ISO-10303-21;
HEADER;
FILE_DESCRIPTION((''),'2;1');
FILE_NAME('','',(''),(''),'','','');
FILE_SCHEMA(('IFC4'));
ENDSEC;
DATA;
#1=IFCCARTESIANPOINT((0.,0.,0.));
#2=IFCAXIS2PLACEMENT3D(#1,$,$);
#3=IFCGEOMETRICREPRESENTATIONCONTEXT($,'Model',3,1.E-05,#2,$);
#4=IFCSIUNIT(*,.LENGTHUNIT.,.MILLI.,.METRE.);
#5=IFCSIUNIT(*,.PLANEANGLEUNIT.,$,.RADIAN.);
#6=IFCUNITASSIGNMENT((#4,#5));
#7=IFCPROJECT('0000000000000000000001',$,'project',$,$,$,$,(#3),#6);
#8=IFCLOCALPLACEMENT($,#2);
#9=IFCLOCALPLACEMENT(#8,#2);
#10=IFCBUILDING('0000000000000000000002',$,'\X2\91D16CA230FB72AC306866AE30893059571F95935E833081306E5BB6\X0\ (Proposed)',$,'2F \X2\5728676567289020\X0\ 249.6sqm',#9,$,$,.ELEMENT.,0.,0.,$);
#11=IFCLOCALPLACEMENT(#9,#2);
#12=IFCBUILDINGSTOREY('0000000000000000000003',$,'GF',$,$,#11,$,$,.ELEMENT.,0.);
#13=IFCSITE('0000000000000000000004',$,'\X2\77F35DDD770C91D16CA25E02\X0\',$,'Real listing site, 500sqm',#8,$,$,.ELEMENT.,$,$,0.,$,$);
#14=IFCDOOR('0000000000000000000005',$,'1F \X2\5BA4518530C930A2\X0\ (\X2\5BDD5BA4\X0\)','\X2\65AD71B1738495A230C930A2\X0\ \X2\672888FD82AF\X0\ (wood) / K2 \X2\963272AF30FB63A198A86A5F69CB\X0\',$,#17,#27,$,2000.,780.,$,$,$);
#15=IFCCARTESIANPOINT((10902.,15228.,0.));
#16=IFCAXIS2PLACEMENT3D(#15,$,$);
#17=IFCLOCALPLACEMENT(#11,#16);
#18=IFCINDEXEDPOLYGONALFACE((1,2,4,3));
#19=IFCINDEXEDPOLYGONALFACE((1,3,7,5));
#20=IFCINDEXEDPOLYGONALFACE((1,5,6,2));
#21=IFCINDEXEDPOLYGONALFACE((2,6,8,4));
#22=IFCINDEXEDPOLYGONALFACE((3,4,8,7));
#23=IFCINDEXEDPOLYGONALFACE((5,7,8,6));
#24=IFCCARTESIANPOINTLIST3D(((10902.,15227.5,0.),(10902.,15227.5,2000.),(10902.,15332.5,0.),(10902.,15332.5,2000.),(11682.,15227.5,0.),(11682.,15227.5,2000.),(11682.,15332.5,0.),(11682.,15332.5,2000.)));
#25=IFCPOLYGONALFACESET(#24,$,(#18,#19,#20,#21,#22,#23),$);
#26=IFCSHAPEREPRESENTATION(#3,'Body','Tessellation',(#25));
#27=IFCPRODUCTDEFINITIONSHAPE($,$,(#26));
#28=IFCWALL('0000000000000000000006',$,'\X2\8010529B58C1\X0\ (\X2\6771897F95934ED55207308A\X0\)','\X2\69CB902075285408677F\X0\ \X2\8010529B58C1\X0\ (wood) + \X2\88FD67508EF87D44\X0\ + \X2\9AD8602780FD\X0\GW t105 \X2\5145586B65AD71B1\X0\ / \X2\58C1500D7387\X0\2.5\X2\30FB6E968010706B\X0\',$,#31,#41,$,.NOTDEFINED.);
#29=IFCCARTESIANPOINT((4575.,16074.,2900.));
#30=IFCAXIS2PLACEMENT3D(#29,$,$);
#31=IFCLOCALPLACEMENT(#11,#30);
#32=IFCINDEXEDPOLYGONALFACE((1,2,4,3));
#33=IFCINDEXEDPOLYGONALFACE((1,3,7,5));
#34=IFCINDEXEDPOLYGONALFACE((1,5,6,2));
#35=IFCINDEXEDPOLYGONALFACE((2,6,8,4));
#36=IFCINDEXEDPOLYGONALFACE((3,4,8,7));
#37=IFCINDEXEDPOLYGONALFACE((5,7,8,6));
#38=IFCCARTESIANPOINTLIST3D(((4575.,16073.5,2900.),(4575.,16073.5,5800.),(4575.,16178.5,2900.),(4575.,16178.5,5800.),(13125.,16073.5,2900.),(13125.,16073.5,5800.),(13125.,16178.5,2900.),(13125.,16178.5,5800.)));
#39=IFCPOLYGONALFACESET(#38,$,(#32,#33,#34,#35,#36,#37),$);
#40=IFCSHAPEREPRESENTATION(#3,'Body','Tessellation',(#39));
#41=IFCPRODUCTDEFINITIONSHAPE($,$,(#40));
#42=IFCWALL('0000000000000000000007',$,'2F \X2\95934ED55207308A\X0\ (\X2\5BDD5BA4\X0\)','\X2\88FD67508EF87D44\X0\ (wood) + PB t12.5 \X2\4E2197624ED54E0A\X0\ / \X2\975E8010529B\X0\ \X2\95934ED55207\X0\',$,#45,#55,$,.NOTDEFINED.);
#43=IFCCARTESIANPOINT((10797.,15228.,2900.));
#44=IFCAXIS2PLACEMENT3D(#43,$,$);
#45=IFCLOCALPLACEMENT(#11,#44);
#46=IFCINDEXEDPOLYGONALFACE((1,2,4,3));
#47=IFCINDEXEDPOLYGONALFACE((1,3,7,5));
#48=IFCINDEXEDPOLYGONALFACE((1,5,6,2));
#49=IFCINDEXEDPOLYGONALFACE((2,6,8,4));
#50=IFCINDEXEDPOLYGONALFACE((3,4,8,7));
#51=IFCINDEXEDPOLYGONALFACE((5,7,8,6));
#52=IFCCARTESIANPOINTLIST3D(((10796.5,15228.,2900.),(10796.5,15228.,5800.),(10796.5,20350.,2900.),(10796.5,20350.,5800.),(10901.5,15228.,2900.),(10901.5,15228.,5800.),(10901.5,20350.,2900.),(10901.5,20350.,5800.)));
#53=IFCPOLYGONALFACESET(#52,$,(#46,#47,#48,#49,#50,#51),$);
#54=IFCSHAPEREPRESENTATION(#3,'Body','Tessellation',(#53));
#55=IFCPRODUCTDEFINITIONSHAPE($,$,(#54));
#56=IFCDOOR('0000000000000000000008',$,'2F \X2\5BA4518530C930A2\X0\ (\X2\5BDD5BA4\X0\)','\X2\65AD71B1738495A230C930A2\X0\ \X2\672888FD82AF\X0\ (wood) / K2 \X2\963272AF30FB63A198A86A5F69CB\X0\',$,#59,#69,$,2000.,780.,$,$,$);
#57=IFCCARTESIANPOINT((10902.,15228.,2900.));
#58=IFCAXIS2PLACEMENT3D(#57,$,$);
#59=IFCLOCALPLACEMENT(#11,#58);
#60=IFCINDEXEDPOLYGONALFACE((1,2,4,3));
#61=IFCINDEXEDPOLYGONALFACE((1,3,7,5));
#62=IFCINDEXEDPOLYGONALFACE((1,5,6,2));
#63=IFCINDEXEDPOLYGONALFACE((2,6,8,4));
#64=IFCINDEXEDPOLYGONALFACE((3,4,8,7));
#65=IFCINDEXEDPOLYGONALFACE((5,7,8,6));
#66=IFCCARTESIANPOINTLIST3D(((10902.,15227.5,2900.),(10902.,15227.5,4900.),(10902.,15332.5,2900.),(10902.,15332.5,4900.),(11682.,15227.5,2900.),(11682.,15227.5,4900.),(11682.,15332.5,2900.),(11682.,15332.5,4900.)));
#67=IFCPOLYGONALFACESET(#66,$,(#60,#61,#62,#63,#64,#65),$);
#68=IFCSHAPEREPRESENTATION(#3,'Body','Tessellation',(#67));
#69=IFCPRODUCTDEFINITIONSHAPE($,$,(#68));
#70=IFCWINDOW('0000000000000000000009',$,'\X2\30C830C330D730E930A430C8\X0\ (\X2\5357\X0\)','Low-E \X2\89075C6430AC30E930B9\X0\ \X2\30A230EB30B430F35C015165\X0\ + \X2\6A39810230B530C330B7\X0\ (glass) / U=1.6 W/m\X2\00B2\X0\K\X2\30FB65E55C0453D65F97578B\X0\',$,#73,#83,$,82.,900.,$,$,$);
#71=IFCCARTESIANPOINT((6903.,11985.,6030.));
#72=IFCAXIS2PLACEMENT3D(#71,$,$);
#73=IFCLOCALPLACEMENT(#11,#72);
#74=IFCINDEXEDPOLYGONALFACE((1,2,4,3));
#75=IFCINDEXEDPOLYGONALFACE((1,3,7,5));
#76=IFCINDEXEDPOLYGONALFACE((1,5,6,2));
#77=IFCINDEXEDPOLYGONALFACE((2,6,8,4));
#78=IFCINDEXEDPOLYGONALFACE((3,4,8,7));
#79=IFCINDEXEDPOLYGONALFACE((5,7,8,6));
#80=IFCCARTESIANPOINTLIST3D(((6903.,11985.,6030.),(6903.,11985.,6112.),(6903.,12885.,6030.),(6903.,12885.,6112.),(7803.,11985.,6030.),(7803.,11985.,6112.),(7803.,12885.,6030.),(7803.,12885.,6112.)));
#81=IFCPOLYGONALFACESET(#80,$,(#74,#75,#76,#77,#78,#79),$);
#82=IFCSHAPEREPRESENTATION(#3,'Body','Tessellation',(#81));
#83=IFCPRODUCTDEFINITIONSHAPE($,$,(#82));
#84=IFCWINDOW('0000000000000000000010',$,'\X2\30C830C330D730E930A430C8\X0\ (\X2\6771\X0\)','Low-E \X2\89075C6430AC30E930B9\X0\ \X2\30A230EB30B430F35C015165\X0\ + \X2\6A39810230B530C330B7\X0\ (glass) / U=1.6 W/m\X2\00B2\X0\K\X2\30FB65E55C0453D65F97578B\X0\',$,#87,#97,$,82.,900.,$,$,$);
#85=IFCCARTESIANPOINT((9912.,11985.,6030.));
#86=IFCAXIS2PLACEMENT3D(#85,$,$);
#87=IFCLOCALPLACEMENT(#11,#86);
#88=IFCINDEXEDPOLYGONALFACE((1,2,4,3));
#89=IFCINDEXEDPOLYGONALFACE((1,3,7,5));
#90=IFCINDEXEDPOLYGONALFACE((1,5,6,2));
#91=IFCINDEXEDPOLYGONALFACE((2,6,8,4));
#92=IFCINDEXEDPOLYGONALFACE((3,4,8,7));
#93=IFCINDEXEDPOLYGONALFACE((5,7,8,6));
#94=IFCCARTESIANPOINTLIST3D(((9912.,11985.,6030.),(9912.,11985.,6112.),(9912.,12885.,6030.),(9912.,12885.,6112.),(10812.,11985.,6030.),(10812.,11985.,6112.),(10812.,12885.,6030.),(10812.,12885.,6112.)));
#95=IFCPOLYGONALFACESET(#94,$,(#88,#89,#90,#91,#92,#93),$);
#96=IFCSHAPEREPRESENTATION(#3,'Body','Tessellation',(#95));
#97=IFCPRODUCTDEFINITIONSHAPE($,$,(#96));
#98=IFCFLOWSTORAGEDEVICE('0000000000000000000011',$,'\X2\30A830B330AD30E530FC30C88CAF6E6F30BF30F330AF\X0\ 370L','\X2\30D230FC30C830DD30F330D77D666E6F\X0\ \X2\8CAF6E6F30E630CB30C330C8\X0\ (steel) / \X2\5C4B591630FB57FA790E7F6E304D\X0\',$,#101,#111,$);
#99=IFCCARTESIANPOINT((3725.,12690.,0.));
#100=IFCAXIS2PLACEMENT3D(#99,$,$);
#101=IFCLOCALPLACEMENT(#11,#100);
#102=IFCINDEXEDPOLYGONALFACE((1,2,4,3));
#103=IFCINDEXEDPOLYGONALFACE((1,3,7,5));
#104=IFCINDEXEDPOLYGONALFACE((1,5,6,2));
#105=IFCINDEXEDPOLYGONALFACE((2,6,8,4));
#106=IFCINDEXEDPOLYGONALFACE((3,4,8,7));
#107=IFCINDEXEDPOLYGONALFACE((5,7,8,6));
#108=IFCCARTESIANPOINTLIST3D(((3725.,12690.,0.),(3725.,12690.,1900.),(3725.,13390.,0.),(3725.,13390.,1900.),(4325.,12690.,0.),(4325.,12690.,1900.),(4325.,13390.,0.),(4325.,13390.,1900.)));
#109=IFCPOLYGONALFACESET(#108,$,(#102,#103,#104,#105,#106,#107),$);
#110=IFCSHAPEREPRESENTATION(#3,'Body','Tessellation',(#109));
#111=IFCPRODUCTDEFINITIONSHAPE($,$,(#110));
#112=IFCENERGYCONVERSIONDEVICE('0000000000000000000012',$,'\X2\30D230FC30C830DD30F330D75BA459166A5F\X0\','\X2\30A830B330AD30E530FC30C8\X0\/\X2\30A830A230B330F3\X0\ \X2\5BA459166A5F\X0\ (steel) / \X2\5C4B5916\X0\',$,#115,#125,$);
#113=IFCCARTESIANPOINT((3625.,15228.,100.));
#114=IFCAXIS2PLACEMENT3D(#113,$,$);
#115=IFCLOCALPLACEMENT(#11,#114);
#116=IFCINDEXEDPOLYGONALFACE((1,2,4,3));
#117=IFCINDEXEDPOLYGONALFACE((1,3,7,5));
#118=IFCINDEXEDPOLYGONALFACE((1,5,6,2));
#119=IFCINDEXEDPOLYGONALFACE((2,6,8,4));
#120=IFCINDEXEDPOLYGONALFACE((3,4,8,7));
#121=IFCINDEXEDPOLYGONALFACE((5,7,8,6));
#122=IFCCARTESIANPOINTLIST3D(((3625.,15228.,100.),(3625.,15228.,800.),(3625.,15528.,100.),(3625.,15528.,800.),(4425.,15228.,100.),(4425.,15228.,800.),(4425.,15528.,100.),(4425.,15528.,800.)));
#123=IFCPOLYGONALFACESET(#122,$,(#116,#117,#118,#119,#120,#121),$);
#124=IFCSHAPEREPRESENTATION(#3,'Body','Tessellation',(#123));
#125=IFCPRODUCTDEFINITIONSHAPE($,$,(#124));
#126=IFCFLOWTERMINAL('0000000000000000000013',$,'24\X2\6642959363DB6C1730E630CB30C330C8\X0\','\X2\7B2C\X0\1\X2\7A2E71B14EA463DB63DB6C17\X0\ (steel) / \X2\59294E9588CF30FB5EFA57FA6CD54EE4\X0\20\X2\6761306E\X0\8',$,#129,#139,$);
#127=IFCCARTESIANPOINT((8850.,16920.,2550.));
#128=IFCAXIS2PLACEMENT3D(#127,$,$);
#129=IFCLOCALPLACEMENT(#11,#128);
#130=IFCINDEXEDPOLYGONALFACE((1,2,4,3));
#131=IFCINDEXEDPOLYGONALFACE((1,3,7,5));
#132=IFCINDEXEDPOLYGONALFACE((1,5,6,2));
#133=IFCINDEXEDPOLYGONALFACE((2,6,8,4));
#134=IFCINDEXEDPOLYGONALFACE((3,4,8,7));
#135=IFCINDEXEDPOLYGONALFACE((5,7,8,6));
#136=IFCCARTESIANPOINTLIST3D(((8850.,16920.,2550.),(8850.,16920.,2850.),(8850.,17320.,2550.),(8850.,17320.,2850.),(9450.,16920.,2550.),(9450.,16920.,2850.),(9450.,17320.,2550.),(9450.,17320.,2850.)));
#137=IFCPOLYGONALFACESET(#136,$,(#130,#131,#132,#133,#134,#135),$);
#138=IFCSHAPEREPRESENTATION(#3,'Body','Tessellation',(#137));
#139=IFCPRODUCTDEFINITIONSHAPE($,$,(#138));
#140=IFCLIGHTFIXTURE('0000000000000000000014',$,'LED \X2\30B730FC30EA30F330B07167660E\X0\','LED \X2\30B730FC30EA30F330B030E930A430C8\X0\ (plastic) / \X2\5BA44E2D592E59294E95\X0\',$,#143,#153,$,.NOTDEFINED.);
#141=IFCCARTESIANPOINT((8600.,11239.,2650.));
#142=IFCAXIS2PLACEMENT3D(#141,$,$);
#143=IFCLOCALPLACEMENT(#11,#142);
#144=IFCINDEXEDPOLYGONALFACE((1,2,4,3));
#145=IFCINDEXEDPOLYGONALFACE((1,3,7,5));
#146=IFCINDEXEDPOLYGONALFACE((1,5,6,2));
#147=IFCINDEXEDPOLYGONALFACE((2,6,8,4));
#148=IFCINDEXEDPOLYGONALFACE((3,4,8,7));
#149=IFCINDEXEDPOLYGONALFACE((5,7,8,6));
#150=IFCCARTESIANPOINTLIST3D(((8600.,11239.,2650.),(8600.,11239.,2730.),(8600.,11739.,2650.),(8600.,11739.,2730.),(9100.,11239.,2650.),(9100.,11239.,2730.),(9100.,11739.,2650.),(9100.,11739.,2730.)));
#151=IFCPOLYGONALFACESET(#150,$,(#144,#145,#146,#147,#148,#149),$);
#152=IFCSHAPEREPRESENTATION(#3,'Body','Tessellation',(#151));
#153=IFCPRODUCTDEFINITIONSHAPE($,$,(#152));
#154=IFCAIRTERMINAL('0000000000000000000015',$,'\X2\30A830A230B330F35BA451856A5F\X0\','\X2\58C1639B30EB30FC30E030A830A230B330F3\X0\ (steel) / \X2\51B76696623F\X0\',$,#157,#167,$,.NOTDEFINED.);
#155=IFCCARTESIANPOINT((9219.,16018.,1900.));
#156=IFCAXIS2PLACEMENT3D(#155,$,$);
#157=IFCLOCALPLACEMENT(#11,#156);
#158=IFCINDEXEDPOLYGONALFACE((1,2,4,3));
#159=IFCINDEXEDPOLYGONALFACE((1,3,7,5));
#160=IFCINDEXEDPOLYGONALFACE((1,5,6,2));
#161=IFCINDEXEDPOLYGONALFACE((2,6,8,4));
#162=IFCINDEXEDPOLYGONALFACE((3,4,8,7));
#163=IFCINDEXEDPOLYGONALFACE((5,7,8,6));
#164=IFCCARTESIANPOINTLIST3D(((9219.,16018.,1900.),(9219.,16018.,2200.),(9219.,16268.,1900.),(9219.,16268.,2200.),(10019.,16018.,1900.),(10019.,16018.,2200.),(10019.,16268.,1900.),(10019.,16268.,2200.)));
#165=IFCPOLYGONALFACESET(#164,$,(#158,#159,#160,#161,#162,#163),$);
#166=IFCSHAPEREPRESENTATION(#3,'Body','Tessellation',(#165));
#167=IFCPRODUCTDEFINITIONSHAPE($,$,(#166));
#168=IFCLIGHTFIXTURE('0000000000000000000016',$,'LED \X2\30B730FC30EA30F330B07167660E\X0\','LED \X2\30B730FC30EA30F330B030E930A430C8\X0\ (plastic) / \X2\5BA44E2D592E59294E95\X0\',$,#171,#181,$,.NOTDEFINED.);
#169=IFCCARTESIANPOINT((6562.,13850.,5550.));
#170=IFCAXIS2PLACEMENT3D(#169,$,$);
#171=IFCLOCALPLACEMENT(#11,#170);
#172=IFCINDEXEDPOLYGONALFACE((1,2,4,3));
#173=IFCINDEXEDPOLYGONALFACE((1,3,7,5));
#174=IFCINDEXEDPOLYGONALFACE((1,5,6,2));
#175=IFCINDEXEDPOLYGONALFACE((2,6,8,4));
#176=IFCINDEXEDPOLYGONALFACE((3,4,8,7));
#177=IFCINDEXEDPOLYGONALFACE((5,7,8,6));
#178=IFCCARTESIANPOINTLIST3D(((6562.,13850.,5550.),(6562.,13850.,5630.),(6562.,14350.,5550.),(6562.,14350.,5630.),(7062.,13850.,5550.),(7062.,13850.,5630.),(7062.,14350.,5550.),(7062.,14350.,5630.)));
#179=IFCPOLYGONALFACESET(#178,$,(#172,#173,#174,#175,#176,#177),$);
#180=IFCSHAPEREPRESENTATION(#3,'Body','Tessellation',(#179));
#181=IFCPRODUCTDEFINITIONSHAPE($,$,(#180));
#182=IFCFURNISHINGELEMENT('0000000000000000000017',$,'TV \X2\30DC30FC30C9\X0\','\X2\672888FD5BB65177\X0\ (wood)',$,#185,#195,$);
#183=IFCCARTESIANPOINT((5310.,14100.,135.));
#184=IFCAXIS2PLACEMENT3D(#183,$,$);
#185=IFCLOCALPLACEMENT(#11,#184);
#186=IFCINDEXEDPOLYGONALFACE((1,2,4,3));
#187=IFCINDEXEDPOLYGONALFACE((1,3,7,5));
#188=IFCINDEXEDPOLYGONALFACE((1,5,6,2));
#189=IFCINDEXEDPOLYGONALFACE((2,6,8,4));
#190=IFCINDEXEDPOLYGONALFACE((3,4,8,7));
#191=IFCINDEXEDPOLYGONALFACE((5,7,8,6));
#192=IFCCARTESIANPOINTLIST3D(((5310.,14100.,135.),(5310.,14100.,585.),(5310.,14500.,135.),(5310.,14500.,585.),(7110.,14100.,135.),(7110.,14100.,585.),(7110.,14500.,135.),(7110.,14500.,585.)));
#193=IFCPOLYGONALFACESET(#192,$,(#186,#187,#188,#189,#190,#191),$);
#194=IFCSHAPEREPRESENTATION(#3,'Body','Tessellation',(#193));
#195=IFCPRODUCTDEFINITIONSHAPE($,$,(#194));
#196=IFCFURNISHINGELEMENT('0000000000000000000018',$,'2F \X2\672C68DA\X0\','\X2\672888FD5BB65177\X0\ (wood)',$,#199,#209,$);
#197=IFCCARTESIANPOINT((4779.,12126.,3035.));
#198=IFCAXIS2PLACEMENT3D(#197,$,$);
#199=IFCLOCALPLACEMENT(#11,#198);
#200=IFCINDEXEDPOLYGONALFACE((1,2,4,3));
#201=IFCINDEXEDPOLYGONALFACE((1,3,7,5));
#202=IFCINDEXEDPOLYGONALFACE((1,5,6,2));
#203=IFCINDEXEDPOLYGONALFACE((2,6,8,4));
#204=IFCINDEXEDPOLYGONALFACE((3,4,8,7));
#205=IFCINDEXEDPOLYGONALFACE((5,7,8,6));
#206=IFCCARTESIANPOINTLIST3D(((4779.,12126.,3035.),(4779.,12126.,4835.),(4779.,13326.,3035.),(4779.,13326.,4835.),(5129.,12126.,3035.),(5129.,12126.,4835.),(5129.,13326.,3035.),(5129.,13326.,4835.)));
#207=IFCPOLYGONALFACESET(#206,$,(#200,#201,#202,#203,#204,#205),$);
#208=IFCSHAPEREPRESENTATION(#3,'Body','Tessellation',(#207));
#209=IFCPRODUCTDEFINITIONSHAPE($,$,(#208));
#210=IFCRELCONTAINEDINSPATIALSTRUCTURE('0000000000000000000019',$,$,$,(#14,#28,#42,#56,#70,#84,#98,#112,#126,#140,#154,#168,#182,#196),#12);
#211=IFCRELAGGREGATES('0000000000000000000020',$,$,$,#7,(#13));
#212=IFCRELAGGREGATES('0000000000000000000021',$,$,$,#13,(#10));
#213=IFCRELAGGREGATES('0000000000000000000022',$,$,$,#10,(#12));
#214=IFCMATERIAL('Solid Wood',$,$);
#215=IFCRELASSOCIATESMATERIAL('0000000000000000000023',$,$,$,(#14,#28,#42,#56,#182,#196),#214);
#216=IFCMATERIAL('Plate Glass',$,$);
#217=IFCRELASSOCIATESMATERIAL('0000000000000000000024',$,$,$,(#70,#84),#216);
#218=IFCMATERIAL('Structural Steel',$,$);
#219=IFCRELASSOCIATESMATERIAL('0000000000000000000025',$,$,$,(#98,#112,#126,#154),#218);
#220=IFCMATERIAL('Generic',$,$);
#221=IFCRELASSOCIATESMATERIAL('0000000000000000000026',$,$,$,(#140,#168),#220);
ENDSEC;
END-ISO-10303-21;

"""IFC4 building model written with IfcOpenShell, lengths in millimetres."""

from ifc_helpers import new_model, si_unit, frame, frame_2d, origin, place, context, project, spatial, rectangle, extrude, material, element, save


model = new_model("IFC4")

# Units and contexts
model_context = context("Model", 3, precision=1e-05, world=origin())
ifc_project = project(units=[si_unit("LENGTHUNIT", "METRE", prefix="MILLI"), si_unit("PLANEANGLEUNIT", "RADIAN")], contexts=[model_context])

# Site, building, storey
site_placement = place(None, origin())
site = spatial("IfcSite", under=ifc_project, at=site_placement, Name="石川県金沢市", ObjectType="Real listing site, 500sqm", CompositionType="ELEMENT", RefElevation=0.0)
building_placement = place(site_placement, origin())
building = spatial("IfcBuilding", under=site, at=building_placement, Name="金沢・犬と暮らす土間広めの家 (Proposed)", ObjectType="2F 在来木造 249.6sqm", CompositionType="ELEMENT", ElevationOfRefHeight=0.0, ElevationOfTerrain=0.0)
storey_placement = place(building_placement, origin())
storey = spatial("IfcBuildingStorey", under=building, at=storey_placement, Name="GF", CompositionType="ELEMENT", Elevation=0.0)

# Shared definitions
ifc_material_1 = material(Name="Solid Wood")

# Door
door_1_placement = place(storey_placement, frame((10902.0, 15228.0, 0.0)))
element("IfcDoor", 1, at=door_1_placement, inside=storey, material=ifc_material_1, Name="1F 室内ドア (寝室)", Description="断熱玄関ドア 木製芯 (wood) / K2 防犯・採風機構", OverallHeight=2000.0, OverallWidth=780.0, context=model_context, shape_type="SweptSolid", body=[
    extrude(rectangle(XDim=780.0, YDim=105.0, at=frame_2d((390.0, 52.0))), frame((10902.0, 15228.0, 0.0)), (0.0, 0.0, 1.0), 2000.0),
])

# Walls
wall_1_placement = place(storey_placement, frame((4575.0, 16074.0, 2900.0)))
element("IfcWall", 2, at=wall_1_placement, inside=storey, material=ifc_material_1, Name="耐力壁 (東西間仕切り)", Description="構造用合板 耐力壁 (wood) + 製材軸組 + 高性能GW t105 充填断熱 / 壁倍率2.5・準耐火", PredefinedType="NOTDEFINED", context=model_context, shape_type="SweptSolid", body=[
    extrude(rectangle(XDim=8550.0, YDim=105.0, at=frame_2d((4275.0, 52.0))), frame((4575.0, 16074.0, 2900.0)), (0.0, 0.0, 1.0), 2900.0),
])
wall_2_placement = place(storey_placement, frame((10797.0, 15228.0, 2900.0)))
element("IfcWall", 3, at=wall_2_placement, inside=storey, material=ifc_material_1, Name="2F 間仕切り (寝室)", Description="製材軸組 (wood) + PB t12.5 両面仕上 / 非耐力 間仕切", PredefinedType="NOTDEFINED", context=model_context, shape_type="SweptSolid", body=[
    extrude(rectangle(XDim=105.0, YDim=5122.0, at=frame_2d((52.0, 2561.0))), frame((10797.0, 15228.0, 2900.0)), (0.0, 0.0, 1.0), 2900.0),
])

# Door
door_2_placement = place(storey_placement, frame((10902.0, 15228.0, 2900.0)))
element("IfcDoor", 4, at=door_2_placement, inside=storey, material=ifc_material_1, Name="2F 室内ドア (寝室)", Description="断熱玄関ドア 木製芯 (wood) / K2 防犯・採風機構", OverallHeight=2000.0, OverallWidth=780.0, context=model_context, shape_type="SweptSolid", body=[
    extrude(rectangle(XDim=780.0, YDim=105.0, at=frame_2d((390.0, 52.0))), frame((10902.0, 15228.0, 2900.0)), (0.0, 0.0, 1.0), 2000.0),
])

# Windows
ifc_material_2 = material(Name="Plate Glass")
window_1_placement = place(storey_placement, frame((6903.0, 11985.0, 6030.0)))
element("IfcWindow", 5, at=window_1_placement, inside=storey, material=ifc_material_2, Name="トップライト (南)", Description="Low-E 複層ガラス アルゴン封入 + 樹脂サッシ (glass) / U=1.6 W/m²K・日射取得型", OverallHeight=82.0, OverallWidth=900.0, context=model_context, shape_type="SweptSolid", body=[
    extrude(rectangle(XDim=900.0, YDim=900.0, at=frame_2d((450.0, 450.0))), frame((6903.0, 11985.0, 6030.0)), (0.0, 0.0, 1.0), 82.0),
])
window_2_placement = place(storey_placement, frame((9912.0, 11985.0, 6030.0)))
element("IfcWindow", 6, at=window_2_placement, inside=storey, material=ifc_material_2, Name="トップライト (東)", Description="Low-E 複層ガラス アルゴン封入 + 樹脂サッシ (glass) / U=1.6 W/m²K・日射取得型", OverallHeight=82.0, OverallWidth=900.0, context=model_context, shape_type="SweptSolid", body=[
    extrude(rectangle(XDim=900.0, YDim=900.0, at=frame_2d((450.0, 450.0))), frame((9912.0, 11985.0, 6030.0)), (0.0, 0.0, 1.0), 82.0),
])

# Flow storage device
ifc_material_3 = material(Name="Structural Steel")
flow_storage_device_placement = place(storey_placement, frame((3725.0, 12690.0, 0.0)))
element("IfcFlowStorageDevice", 7, at=flow_storage_device_placement, inside=storey, material=ifc_material_3, Name="エコキュート貯湯タンク 370L", Description="ヒートポンプ給湯 貯湯ユニット (steel) / 屋外・基礎置き", context=model_context, shape_type="SweptSolid", body=[
    extrude(rectangle(XDim=600.0, YDim=700.0, at=frame_2d((300.0, 350.0))), frame((3725.0, 12690.0, 0.0)), (0.0, 0.0, 1.0), 1900.0),
])

# Energy conversion device
energy_conversion_device_placement = place(storey_placement, frame((3625.0, 15228.0, 100.0)))
element("IfcEnergyConversionDevice", 8, at=energy_conversion_device_placement, inside=storey, material=ifc_material_3, Name="ヒートポンプ室外機", Description="エコキュート/エアコン 室外機 (steel) / 屋外", context=model_context, shape_type="SweptSolid", body=[
    extrude(rectangle(XDim=800.0, YDim=300.0, at=frame_2d((400.0, 150.0))), frame((3625.0, 15228.0, 100.0)), (0.0, 0.0, 1.0), 700.0),
])

# Flow terminal
flow_terminal_placement = place(storey_placement, frame((8850.0, 16920.0, 2550.0)))
element("IfcFlowTerminal", 9, at=flow_terminal_placement, inside=storey, material=ifc_material_3, Name="24時間換気ユニット", Description="第1種熱交換換気 (steel) / 天井裏・建基法令20条の8", context=model_context, shape_type="SweptSolid", body=[
    extrude(rectangle(XDim=600.0, YDim=400.0, at=frame_2d((300.0, 200.0))), frame((8850.0, 16920.0, 2550.0)), (0.0, 0.0, 1.0), 300.0),
])

# Light fixture
ifc_material_4 = material(Name="Generic")
light_fixture_1_placement = place(storey_placement, frame((8600.0, 11239.0, 2650.0)))
element("IfcLightFixture", 10, at=light_fixture_1_placement, inside=storey, material=ifc_material_4, Name="LED シーリング照明", Description="LED シーリングライト (plastic) / 室中央天井", PredefinedType="NOTDEFINED", context=model_context, shape_type="SweptSolid", body=[
    extrude(rectangle(XDim=500.0, YDim=500.0, at=frame_2d((250.0, 250.0))), frame((8600.0, 11239.0, 2650.0)), (0.0, 0.0, 1.0), 80.0),
])

# Air terminal
air_terminal_placement = place(storey_placement, frame((9219.0, 16018.0, 1900.0)))
element("IfcAirTerminal", 11, at=air_terminal_placement, inside=storey, material=ifc_material_3, Name="エアコン室内機", Description="壁掛ルームエアコン (steel) / 冷暖房", PredefinedType="NOTDEFINED", context=model_context, shape_type="SweptSolid", body=[
    extrude(rectangle(XDim=800.0, YDim=250.0, at=frame_2d((400.0, 125.0))), frame((9219.0, 16018.0, 1900.0)), (0.0, 0.0, 1.0), 300.0),
])

# Light fixture
light_fixture_2_placement = place(storey_placement, frame((6562.0, 13850.0, 5550.0)))
element("IfcLightFixture", 12, at=light_fixture_2_placement, inside=storey, material=ifc_material_4, Name="LED シーリング照明", Description="LED シーリングライト (plastic) / 室中央天井", PredefinedType="NOTDEFINED", context=model_context, shape_type="SweptSolid", body=[
    extrude(rectangle(XDim=500.0, YDim=500.0, at=frame_2d((250.0, 250.0))), frame((6562.0, 13850.0, 5550.0)), (0.0, 0.0, 1.0), 80.0),
])

# Furnishing elements
furnishing_1_placement = place(storey_placement, frame((5310.0, 14100.0, 135.0)))
element("IfcFurnishingElement", 13, at=furnishing_1_placement, inside=storey, material=ifc_material_1, Name="TV ボード", Description="木製家具 (wood)", context=model_context, shape_type="SweptSolid", body=[
    extrude(rectangle(XDim=1800.0, YDim=400.0, at=frame_2d((900.0, 200.0))), frame((5310.0, 14100.0, 135.0)), (0.0, 0.0, 1.0), 450.0),
])
furnishing_2_placement = place(storey_placement, frame((4779.0, 12126.0, 3035.0)))
element("IfcFurnishingElement", 14, at=furnishing_2_placement, inside=storey, material=ifc_material_1, Name="2F 本棚", Description="木製家具 (wood)", context=model_context, shape_type="SweptSolid", body=[
    extrude(rectangle(XDim=350.0, YDim=1200.0, at=frame_2d((175.0, 600.0))), frame((4779.0, 12126.0, 3035.0)), (0.0, 0.0, 1.0), 1800.0),
])

save(model, "model.ifc")
